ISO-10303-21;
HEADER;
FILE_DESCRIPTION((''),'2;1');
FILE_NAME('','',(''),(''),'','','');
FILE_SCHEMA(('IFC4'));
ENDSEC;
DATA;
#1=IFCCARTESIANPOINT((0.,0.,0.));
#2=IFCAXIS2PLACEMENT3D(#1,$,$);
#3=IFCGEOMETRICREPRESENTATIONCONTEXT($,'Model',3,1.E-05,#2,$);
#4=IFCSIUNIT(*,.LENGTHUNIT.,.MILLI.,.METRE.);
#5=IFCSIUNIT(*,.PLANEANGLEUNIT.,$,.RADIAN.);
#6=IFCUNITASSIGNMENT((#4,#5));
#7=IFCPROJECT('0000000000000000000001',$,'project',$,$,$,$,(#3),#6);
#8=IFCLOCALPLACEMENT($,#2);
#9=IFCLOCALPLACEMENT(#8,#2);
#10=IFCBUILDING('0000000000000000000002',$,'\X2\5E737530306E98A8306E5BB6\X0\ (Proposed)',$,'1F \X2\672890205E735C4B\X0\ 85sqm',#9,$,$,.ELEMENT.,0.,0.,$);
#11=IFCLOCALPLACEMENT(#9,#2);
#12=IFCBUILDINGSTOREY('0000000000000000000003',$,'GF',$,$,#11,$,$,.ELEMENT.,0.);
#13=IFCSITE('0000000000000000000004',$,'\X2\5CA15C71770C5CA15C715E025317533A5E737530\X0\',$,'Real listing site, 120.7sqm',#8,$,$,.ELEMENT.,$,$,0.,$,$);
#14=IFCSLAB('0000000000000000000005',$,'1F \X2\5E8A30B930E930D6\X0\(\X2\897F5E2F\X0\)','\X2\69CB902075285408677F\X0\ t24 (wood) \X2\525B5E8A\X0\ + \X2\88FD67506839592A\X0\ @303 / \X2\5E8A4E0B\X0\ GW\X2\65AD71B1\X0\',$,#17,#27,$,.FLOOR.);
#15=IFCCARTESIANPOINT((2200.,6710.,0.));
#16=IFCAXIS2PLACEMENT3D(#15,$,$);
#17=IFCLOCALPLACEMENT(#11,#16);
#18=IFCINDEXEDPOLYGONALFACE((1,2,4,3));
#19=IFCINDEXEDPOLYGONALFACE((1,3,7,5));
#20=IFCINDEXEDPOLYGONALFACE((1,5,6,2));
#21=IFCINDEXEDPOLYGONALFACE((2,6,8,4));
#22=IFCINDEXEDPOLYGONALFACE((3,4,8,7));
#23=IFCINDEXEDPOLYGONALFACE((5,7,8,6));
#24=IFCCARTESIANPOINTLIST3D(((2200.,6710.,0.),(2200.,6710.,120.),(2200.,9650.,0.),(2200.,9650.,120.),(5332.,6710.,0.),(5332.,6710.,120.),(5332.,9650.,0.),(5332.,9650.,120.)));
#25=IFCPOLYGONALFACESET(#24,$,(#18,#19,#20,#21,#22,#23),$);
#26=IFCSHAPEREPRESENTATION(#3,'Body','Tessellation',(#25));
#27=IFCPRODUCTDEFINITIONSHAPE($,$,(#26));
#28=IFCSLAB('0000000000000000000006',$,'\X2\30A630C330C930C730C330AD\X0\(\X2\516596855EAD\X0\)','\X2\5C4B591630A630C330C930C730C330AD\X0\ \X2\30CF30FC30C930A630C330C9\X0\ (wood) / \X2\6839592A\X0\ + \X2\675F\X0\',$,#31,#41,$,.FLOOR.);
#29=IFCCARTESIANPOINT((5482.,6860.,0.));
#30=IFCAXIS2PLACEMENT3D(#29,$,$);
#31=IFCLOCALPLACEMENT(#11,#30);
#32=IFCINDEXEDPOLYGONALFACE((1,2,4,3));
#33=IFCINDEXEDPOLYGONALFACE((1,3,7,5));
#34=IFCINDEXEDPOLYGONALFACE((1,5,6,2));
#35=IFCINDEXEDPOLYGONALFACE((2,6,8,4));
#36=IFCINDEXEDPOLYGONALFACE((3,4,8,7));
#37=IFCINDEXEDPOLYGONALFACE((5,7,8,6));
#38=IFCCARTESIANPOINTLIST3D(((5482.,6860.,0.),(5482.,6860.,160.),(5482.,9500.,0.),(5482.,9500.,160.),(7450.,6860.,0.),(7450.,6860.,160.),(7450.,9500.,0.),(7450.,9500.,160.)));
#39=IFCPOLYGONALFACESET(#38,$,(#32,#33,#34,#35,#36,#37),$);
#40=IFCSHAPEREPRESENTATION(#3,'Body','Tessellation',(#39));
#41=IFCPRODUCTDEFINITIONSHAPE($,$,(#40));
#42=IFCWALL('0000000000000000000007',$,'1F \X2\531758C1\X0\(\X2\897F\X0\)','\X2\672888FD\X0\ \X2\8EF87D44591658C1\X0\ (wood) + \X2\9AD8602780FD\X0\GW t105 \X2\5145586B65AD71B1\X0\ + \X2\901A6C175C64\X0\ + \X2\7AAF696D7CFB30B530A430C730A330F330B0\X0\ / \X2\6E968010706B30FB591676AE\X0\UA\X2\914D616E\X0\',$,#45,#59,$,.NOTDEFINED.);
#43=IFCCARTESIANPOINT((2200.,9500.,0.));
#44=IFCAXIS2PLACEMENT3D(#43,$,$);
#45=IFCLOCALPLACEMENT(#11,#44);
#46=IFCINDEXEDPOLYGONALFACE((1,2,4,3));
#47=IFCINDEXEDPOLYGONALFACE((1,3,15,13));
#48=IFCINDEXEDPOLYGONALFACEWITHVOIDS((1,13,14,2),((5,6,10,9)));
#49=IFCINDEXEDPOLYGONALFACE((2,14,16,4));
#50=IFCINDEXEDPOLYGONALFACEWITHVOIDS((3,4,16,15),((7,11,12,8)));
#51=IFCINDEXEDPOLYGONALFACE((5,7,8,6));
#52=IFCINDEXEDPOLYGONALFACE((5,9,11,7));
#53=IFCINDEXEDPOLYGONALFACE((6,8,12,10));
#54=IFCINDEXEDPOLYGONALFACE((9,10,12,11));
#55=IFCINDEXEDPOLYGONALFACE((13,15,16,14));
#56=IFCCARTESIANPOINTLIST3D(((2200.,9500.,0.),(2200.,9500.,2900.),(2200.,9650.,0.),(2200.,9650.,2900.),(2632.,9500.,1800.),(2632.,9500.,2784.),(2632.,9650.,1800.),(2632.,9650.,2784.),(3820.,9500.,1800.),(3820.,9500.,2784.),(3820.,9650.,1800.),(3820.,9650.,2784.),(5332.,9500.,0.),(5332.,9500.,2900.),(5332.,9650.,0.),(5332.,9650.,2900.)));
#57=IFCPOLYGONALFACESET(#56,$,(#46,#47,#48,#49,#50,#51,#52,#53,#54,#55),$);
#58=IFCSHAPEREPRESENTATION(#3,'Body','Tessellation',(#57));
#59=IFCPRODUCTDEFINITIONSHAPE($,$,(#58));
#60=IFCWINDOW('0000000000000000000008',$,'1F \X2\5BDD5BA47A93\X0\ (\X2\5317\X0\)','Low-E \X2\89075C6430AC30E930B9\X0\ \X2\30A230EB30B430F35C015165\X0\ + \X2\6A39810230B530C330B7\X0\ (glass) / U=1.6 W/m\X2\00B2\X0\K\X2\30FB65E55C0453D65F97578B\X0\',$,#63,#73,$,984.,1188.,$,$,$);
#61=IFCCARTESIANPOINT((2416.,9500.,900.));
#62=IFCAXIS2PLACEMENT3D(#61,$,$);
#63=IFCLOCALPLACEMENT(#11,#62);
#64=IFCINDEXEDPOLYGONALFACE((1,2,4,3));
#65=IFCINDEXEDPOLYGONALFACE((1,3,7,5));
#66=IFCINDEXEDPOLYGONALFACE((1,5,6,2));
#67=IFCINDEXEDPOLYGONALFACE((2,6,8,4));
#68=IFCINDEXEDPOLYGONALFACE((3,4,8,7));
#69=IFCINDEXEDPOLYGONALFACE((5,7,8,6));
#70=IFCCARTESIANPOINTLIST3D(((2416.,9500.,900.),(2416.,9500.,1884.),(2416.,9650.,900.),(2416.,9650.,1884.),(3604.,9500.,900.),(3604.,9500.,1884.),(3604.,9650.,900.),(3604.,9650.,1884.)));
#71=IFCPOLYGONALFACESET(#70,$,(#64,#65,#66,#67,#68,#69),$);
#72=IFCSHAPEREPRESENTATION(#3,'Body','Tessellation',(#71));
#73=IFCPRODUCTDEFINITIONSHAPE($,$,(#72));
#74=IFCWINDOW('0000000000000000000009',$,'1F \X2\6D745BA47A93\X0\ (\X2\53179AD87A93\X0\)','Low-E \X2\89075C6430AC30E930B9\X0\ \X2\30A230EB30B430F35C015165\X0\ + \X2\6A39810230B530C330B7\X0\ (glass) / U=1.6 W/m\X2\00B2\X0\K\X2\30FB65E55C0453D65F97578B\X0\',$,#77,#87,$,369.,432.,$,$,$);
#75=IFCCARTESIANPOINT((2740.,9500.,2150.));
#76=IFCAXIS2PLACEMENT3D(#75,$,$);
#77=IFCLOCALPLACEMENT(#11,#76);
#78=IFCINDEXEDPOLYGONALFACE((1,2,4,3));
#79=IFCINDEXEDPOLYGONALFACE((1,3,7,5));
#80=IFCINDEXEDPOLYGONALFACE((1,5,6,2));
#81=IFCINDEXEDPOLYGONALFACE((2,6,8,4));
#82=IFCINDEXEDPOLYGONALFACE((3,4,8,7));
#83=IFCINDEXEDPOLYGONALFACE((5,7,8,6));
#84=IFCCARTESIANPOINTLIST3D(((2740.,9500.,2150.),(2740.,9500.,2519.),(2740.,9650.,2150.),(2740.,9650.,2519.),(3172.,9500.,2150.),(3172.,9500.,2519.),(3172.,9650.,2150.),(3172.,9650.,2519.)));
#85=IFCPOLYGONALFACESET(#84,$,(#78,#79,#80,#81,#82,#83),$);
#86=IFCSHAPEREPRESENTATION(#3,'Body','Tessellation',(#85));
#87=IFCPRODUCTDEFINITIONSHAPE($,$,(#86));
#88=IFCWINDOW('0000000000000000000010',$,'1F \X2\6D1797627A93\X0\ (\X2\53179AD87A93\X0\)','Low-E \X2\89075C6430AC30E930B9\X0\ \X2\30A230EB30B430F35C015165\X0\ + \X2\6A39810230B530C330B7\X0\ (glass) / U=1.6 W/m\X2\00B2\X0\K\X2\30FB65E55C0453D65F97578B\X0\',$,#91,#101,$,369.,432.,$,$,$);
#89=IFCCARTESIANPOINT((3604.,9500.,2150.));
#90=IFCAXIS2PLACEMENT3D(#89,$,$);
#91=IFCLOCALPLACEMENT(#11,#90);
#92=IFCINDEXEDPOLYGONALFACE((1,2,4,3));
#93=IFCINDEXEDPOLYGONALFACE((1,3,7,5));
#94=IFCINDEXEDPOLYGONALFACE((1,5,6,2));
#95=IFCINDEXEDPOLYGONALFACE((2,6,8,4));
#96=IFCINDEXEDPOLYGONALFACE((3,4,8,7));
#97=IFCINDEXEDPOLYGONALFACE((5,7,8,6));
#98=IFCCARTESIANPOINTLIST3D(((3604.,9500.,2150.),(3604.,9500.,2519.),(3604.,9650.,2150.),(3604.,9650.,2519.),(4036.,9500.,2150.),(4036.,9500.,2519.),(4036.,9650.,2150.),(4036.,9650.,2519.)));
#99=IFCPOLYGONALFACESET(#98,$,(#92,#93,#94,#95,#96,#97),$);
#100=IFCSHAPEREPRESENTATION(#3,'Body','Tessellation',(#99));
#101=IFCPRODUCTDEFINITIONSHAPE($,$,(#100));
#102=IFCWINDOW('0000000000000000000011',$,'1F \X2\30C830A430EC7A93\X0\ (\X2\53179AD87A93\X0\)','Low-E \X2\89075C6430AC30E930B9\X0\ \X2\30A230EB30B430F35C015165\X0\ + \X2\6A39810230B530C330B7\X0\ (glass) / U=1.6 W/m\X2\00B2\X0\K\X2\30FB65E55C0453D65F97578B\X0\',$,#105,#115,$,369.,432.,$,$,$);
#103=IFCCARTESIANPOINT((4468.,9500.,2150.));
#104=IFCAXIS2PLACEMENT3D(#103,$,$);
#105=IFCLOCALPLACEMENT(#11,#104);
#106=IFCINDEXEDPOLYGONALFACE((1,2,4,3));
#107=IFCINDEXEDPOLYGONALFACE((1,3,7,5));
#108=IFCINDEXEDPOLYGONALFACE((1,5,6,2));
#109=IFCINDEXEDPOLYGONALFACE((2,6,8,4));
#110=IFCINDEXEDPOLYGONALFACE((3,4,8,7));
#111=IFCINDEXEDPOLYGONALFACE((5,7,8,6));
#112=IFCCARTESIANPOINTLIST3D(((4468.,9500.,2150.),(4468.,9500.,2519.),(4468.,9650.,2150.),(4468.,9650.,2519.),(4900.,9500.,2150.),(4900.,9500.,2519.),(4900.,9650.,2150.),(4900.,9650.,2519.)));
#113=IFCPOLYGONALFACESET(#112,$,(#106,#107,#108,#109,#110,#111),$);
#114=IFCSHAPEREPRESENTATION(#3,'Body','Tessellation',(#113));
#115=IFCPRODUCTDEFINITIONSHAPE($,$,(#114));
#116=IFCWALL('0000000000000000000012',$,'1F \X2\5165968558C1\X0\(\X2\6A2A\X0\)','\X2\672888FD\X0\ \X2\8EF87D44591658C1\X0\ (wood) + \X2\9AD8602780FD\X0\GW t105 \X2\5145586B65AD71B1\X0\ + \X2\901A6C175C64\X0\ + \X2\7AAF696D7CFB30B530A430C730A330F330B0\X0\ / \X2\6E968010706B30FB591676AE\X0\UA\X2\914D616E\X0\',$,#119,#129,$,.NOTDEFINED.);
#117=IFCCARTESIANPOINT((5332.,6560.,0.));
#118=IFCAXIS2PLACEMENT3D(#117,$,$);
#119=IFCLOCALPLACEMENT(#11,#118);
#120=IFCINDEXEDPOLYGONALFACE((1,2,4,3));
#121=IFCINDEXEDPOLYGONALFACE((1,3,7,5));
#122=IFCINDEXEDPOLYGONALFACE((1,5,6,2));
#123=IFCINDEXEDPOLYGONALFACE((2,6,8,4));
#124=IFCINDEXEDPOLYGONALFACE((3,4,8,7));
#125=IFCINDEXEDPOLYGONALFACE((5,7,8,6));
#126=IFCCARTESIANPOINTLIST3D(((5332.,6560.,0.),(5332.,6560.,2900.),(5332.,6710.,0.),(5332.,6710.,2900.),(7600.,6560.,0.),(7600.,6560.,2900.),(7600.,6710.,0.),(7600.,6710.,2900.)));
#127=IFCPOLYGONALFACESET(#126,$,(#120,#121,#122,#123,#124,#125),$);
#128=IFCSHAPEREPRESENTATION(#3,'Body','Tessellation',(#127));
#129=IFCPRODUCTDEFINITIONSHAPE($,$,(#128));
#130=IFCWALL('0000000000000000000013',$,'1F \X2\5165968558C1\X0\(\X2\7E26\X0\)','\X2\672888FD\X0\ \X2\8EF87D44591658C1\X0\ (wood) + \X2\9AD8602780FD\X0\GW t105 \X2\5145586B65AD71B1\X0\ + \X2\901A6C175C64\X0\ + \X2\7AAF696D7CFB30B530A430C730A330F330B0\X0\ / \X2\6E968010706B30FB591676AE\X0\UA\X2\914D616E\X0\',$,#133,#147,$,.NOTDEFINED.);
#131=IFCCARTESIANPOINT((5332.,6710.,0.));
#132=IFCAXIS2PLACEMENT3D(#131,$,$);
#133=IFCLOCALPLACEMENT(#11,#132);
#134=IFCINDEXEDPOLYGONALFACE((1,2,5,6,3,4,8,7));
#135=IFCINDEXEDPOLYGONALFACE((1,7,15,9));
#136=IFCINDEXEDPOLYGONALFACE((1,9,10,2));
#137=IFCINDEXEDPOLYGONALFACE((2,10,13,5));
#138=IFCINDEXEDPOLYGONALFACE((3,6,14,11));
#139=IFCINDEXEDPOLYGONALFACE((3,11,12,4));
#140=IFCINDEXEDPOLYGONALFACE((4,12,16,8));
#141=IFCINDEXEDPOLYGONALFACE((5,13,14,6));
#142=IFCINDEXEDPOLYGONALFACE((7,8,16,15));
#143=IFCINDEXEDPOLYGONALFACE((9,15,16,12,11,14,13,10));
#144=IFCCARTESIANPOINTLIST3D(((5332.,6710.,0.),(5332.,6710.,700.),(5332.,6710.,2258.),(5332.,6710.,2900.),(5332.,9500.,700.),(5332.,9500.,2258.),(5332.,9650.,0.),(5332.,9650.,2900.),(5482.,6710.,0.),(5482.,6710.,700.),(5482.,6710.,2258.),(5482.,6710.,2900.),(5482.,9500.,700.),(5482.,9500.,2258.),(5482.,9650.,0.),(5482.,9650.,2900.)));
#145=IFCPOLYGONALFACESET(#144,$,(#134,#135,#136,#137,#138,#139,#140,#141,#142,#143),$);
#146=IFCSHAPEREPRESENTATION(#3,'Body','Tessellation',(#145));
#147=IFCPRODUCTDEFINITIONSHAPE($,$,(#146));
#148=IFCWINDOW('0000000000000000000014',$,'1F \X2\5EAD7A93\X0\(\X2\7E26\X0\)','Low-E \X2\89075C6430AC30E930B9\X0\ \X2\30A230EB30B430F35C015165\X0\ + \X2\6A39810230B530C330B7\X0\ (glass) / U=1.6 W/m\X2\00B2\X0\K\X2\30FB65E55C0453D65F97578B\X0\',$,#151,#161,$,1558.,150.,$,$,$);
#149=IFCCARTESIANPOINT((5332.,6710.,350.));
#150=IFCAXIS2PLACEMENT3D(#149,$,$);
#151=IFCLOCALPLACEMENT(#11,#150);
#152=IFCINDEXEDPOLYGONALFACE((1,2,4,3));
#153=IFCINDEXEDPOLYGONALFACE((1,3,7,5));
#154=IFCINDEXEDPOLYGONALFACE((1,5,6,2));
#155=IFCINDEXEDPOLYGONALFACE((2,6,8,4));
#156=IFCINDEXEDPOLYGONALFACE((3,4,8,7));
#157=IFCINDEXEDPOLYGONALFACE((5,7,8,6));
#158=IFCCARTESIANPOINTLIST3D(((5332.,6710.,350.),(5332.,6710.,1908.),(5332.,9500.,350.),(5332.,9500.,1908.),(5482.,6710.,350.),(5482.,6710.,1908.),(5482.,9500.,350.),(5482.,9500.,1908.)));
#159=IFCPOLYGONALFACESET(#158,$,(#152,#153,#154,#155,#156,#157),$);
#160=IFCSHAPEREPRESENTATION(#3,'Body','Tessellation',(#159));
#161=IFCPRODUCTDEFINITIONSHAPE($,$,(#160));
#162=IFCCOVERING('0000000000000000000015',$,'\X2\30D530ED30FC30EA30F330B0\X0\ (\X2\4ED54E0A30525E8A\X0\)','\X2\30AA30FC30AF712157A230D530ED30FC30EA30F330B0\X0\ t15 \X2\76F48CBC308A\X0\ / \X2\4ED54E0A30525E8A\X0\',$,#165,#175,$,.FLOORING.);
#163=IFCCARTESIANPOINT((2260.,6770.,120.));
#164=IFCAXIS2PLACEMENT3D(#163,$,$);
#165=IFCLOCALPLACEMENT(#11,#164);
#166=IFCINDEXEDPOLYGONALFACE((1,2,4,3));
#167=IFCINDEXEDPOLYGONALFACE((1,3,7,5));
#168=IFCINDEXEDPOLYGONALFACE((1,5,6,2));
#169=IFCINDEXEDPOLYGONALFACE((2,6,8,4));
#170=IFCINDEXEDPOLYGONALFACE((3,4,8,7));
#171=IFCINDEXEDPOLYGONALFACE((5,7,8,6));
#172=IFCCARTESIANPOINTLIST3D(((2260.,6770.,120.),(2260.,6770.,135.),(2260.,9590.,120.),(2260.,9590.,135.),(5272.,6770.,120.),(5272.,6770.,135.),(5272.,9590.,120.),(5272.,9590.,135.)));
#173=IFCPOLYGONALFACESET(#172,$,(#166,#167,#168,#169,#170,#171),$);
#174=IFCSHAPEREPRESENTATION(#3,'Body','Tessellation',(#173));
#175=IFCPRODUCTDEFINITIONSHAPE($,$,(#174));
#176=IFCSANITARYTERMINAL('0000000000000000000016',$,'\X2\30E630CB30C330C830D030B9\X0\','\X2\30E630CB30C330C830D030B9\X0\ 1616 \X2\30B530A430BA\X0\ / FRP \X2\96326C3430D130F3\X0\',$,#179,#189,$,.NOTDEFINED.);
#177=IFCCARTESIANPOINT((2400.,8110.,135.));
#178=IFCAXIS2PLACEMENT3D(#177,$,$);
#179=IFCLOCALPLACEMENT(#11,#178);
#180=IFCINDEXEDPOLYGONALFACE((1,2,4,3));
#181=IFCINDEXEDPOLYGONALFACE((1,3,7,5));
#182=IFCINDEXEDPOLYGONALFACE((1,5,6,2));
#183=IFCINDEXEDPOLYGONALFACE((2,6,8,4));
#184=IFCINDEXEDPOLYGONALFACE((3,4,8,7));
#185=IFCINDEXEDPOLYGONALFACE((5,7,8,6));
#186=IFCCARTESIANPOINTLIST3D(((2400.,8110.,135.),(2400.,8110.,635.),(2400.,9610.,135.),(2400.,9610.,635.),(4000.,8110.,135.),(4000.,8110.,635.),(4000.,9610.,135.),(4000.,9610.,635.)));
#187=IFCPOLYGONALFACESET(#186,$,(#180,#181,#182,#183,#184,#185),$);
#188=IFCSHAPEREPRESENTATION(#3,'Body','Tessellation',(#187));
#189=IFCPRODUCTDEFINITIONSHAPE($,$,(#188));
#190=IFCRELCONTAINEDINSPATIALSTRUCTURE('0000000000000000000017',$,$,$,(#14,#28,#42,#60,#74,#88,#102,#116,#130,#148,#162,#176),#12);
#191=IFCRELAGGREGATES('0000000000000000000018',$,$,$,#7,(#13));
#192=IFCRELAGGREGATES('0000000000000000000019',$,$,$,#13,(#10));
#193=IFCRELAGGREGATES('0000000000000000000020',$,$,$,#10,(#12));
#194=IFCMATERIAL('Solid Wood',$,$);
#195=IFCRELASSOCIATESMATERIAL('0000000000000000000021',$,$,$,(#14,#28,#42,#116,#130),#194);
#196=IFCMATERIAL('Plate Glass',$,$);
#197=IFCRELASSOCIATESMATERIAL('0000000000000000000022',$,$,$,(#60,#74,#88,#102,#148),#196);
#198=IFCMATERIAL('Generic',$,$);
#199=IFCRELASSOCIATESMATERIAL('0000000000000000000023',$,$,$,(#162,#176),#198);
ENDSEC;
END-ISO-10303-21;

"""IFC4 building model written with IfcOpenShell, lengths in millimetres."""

from ifc_helpers import new_model, si_unit, frame, frame_2d, origin, place, context, project, spatial, rectangle, extrude, material, element, fill, save


model = new_model("IFC4")

# Units and contexts
model_context = context("Model", 3, precision=1e-05, world=origin())
ifc_project = project(units=[si_unit("LENGTHUNIT", "METRE", prefix="MILLI"), si_unit("PLANEANGLEUNIT", "RADIAN")], contexts=[model_context])

# Site, building, storey
site_placement = place(None, origin())
site = spatial("IfcSite", under=ifc_project, at=site_placement, Name="岡山県岡山市北区平田", ObjectType="Real listing site, 120.7sqm", CompositionType="ELEMENT", RefElevation=0.0)
building_placement = place(site_placement, origin())
building = spatial("IfcBuilding", under=site, at=building_placement, Name="平田の風の家 (Proposed)", ObjectType="1F 木造平屋 85sqm", CompositionType="ELEMENT", ElevationOfRefHeight=0.0, ElevationOfTerrain=0.0)
storey_placement = place(building_placement, origin())
storey = spatial("IfcBuildingStorey", under=building, at=storey_placement, Name="GF", CompositionType="ELEMENT", Elevation=0.0)

# Slabs
ifc_material_1 = material(Name="Solid Wood")
slab_1_placement = place(storey_placement, frame((2200.0, 6710.0, 0.0)))
element("IfcSlab", 1, at=slab_1_placement, inside=storey, material=ifc_material_1, Name="1F 床スラブ(西帯)", Description="構造用合板 t24 (wood) 剛床 + 製材根太 @303 / 床下 GW断熱", PredefinedType="FLOOR", context=model_context, shape_type="SweptSolid", body=[
    extrude(rectangle(XDim=3132.0, YDim=2940.0, at=frame_2d((1566.0, 1470.0))), frame((2200.0, 6710.0, 0.0)), (0.0, 0.0, 1.0), 120.0),
])
slab_2_placement = place(storey_placement, frame((5482.0, 6860.0, 0.0)))
element("IfcSlab", 2, at=slab_2_placement, inside=storey, material=ifc_material_1, Name="ウッドデッキ(入隅庭)", Description="屋外ウッドデッキ ハードウッド (wood) / 根太 + 束", PredefinedType="FLOOR", context=model_context, shape_type="SweptSolid", body=[
    extrude(rectangle(XDim=1968.0, YDim=2640.0, at=frame_2d((984.0, 1320.0))), frame((5482.0, 6860.0, 0.0)), (0.0, 0.0, 1.0), 160.0),
])

# Wall, openings, windows
wall_1_placement = place(storey_placement, frame((2200.0, 9500.0, 0.0)))
wall_1 = element("IfcWall", 3, at=wall_1_placement, inside=storey, material=ifc_material_1, Name="1F 北壁(西)", Description="木製 軸組外壁 (wood) + 高性能GW t105 充填断熱 + 通気層 + 窯業系サイディング / 準耐火・外皮UA配慮", PredefinedType="NOTDEFINED", context=model_context, shape_type="SweptSolid", body=[
    extrude(rectangle(XDim=3132.0, YDim=150.0, at=frame_2d((1566.0, 75.0))), frame((2200.0, 9500.0, 0.0)), (0.0, 0.0, 1.0), 2900.0),
])
opening_1_placement = place(storey_placement, frame((2416.0, 9500.0, 900.0)))
opening_1 = element("IfcOpeningElement", 4, at=opening_1_placement, cuts=wall_1, PredefinedType="NOTDEFINED", context=model_context, shape_type="SweptSolid", body=[
    extrude(rectangle(XDim=1188.0, YDim=150.0, at=frame_2d((594.0, 75.0))), frame((2416.0, 9500.0, 900.0)), (0.0, 0.0, 1.0), 984.0),
])
opening_2_placement = place(storey_placement, frame((2740.0, 9500.0, 2150.0)))
opening_2 = element("IfcOpeningElement", 5, at=opening_2_placement, cuts=wall_1, PredefinedType="NOTDEFINED", context=model_context, shape_type="SweptSolid", body=[
    extrude(rectangle(XDim=432.0, YDim=150.0, at=frame_2d((216.0, 75.0))), frame((2740.0, 9500.0, 2150.0)), (0.0, 0.0, 1.0), 369.0),
])
opening_3_placement = place(storey_placement, frame((3604.0, 9500.0, 2150.0)))
opening_3 = element("IfcOpeningElement", 6, at=opening_3_placement, cuts=wall_1, PredefinedType="NOTDEFINED", context=model_context, shape_type="SweptSolid", body=[
    extrude(rectangle(XDim=432.0, YDim=150.0, at=frame_2d((216.0, 75.0))), frame((3604.0, 9500.0, 2150.0)), (0.0, 0.0, 1.0), 369.0),
])
opening_4_placement = place(storey_placement, frame((4468.0, 9500.0, 2150.0)))
opening_4 = element("IfcOpeningElement", 7, at=opening_4_placement, cuts=wall_1, PredefinedType="NOTDEFINED", context=model_context, shape_type="SweptSolid", body=[
    extrude(rectangle(XDim=432.0, YDim=150.0, at=frame_2d((216.0, 75.0))), frame((4468.0, 9500.0, 2150.0)), (0.0, 0.0, 1.0), 369.0),
])
ifc_material_2 = material(Name="Plate Glass")
window_1_placement = place(storey_placement, frame((2416.0, 9500.0, 900.0)))
window_1 = element("IfcWindow", 8, at=window_1_placement, inside=storey, material=ifc_material_2, Name="1F 寝室窓 (北)", Description="Low-E 複層ガラス アルゴン封入 + 樹脂サッシ (glass) / U=1.6 W/m²K・日射取得型", OverallHeight=984.0, OverallWidth=1188.0, context=model_context, shape_type="SweptSolid", body=[
    extrude(rectangle(XDim=1188.0, YDim=150.0, at=frame_2d((594.0, 75.0))), frame((2416.0, 9500.0, 900.0)), (0.0, 0.0, 1.0), 984.0),
])
fill(opening_1, window_1)
window_2_placement = place(storey_placement, frame((2740.0, 9500.0, 2150.0)))
window_2 = element("IfcWindow", 9, at=window_2_placement, inside=storey, material=ifc_material_2, Name="1F 浴室窓 (北高窓)", Description="Low-E 複層ガラス アルゴン封入 + 樹脂サッシ (glass) / U=1.6 W/m²K・日射取得型", OverallHeight=369.0, OverallWidth=432.0, context=model_context, shape_type="SweptSolid", body=[
    extrude(rectangle(XDim=432.0, YDim=150.0, at=frame_2d((216.0, 75.0))), frame((2740.0, 9500.0, 2150.0)), (0.0, 0.0, 1.0), 369.0),
])
fill(opening_2, window_2)
window_3_placement = place(storey_placement, frame((3604.0, 9500.0, 2150.0)))
window_3 = element("IfcWindow", 10, at=window_3_placement, inside=storey, material=ifc_material_2, Name="1F 洗面窓 (北高窓)", Description="Low-E 複層ガラス アルゴン封入 + 樹脂サッシ (glass) / U=1.6 W/m²K・日射取得型", OverallHeight=369.0, OverallWidth=432.0, context=model_context, shape_type="SweptSolid", body=[
    extrude(rectangle(XDim=432.0, YDim=150.0, at=frame_2d((216.0, 75.0))), frame((3604.0, 9500.0, 2150.0)), (0.0, 0.0, 1.0), 369.0),
])
fill(opening_3, window_3)
window_4_placement = place(storey_placement, frame((4468.0, 9500.0, 2150.0)))
window_4 = element("IfcWindow", 11, at=window_4_placement, inside=storey, material=ifc_material_2, Name="1F トイレ窓 (北高窓)", Description="Low-E 複層ガラス アルゴン封入 + 樹脂サッシ (glass) / U=1.6 W/m²K・日射取得型", OverallHeight=369.0, OverallWidth=432.0, context=model_context, shape_type="SweptSolid", body=[
    extrude(rectangle(XDim=432.0, YDim=150.0, at=frame_2d((216.0, 75.0))), frame((4468.0, 9500.0, 2150.0)), (0.0, 0.0, 1.0), 369.0),
])
fill(opening_4, window_4)

# Wall
wall_2_placement = place(storey_placement, frame((5332.0, 6560.0, 0.0)))
element("IfcWall", 12, at=wall_2_placement, inside=storey, material=ifc_material_1, Name="1F 入隅壁(横)", Description="木製 軸組外壁 (wood) + 高性能GW t105 充填断熱 + 通気層 + 窯業系サイディング / 準耐火・外皮UA配慮", PredefinedType="NOTDEFINED", context=model_context, shape_type="SweptSolid", body=[
    extrude(rectangle(XDim=2268.0, YDim=150.0, at=frame_2d((1134.0, 75.0))), frame((5332.0, 6560.0, 0.0)), (0.0, 0.0, 1.0), 2900.0),
])

# Wall, opening, window
wall_3_placement = place(storey_placement, frame((5332.0, 6710.0, 0.0)))
wall_3 = element("IfcWall", 13, at=wall_3_placement, inside=storey, material=ifc_material_1, Name="1F 入隅壁(縦)", Description="木製 軸組外壁 (wood) + 高性能GW t105 充填断熱 + 通気層 + 窯業系サイディング / 準耐火・外皮UA配慮", PredefinedType="NOTDEFINED", context=model_context, shape_type="SweptSolid", body=[
    extrude(rectangle(XDim=150.0, YDim=2940.0, at=frame_2d((75.0, 1470.0))), frame((5332.0, 6710.0, 0.0)), (0.0, 0.0, 1.0), 2900.0),
])
opening_5_placement = place(storey_placement, frame((5332.0, 6710.0, 350.0)))
opening_5 = element("IfcOpeningElement", 14, at=opening_5_placement, cuts=wall_3, PredefinedType="NOTDEFINED", context=model_context, shape_type="SweptSolid", body=[
    extrude(rectangle(XDim=150.0, YDim=2790.0, at=frame_2d((75.0, 1395.0))), frame((5332.0, 6710.0, 350.0)), (0.0, 0.0, 1.0), 1558.0),
])
window_5_placement = place(storey_placement, frame((5332.0, 6710.0, 350.0)))
window_5 = element("IfcWindow", 15, at=window_5_placement, inside=storey, material=ifc_material_2, Name="1F 庭窓(縦)", Description="Low-E 複層ガラス アルゴン封入 + 樹脂サッシ (glass) / U=1.6 W/m²K・日射取得型", OverallHeight=1558.0, OverallWidth=150.0, context=model_context, shape_type="SweptSolid", body=[
    extrude(rectangle(XDim=150.0, YDim=2790.0, at=frame_2d((75.0, 1395.0))), frame((5332.0, 6710.0, 350.0)), (0.0, 0.0, 1.0), 1558.0),
])
fill(opening_5, window_5)

# Covering
ifc_material_3 = material(Name="Generic")
covering_placement = place(storey_placement, frame((2260.0, 6770.0, 120.0)))
element("IfcCovering", 16, at=covering_placement, inside=storey, material=ifc_material_3, Name="フローリング (仕上げ床)", Description="オーク無垢フローリング t15 直貼り / 仕上げ床", PredefinedType="FLOORING", context=model_context, shape_type="SweptSolid", body=[
    extrude(rectangle(XDim=3012.0, YDim=2820.0, at=frame_2d((1506.0, 1410.0))), frame((2260.0, 6770.0, 120.0)), (0.0, 0.0, 1.0), 15.0),
])

# Sanitary terminal
sanitary_terminal_1_placement = place(storey_placement, frame((2400.0, 8110.0, 135.0)))
element("IfcSanitaryTerminal", 17, at=sanitary_terminal_1_placement, inside=storey, material=ifc_material_3, Name="ユニットバス", Description="ユニットバス 1616 サイズ / FRP 防水パン", PredefinedType="NOTDEFINED", context=model_context, shape_type="SweptSolid", body=[
    extrude(rectangle(XDim=1600.0, YDim=1500.0, at=frame_2d((800.0, 750.0))), frame((2400.0, 8110.0, 135.0)), (0.0, 0.0, 1.0), 500.0),
])

save(model, "model.ifc")
